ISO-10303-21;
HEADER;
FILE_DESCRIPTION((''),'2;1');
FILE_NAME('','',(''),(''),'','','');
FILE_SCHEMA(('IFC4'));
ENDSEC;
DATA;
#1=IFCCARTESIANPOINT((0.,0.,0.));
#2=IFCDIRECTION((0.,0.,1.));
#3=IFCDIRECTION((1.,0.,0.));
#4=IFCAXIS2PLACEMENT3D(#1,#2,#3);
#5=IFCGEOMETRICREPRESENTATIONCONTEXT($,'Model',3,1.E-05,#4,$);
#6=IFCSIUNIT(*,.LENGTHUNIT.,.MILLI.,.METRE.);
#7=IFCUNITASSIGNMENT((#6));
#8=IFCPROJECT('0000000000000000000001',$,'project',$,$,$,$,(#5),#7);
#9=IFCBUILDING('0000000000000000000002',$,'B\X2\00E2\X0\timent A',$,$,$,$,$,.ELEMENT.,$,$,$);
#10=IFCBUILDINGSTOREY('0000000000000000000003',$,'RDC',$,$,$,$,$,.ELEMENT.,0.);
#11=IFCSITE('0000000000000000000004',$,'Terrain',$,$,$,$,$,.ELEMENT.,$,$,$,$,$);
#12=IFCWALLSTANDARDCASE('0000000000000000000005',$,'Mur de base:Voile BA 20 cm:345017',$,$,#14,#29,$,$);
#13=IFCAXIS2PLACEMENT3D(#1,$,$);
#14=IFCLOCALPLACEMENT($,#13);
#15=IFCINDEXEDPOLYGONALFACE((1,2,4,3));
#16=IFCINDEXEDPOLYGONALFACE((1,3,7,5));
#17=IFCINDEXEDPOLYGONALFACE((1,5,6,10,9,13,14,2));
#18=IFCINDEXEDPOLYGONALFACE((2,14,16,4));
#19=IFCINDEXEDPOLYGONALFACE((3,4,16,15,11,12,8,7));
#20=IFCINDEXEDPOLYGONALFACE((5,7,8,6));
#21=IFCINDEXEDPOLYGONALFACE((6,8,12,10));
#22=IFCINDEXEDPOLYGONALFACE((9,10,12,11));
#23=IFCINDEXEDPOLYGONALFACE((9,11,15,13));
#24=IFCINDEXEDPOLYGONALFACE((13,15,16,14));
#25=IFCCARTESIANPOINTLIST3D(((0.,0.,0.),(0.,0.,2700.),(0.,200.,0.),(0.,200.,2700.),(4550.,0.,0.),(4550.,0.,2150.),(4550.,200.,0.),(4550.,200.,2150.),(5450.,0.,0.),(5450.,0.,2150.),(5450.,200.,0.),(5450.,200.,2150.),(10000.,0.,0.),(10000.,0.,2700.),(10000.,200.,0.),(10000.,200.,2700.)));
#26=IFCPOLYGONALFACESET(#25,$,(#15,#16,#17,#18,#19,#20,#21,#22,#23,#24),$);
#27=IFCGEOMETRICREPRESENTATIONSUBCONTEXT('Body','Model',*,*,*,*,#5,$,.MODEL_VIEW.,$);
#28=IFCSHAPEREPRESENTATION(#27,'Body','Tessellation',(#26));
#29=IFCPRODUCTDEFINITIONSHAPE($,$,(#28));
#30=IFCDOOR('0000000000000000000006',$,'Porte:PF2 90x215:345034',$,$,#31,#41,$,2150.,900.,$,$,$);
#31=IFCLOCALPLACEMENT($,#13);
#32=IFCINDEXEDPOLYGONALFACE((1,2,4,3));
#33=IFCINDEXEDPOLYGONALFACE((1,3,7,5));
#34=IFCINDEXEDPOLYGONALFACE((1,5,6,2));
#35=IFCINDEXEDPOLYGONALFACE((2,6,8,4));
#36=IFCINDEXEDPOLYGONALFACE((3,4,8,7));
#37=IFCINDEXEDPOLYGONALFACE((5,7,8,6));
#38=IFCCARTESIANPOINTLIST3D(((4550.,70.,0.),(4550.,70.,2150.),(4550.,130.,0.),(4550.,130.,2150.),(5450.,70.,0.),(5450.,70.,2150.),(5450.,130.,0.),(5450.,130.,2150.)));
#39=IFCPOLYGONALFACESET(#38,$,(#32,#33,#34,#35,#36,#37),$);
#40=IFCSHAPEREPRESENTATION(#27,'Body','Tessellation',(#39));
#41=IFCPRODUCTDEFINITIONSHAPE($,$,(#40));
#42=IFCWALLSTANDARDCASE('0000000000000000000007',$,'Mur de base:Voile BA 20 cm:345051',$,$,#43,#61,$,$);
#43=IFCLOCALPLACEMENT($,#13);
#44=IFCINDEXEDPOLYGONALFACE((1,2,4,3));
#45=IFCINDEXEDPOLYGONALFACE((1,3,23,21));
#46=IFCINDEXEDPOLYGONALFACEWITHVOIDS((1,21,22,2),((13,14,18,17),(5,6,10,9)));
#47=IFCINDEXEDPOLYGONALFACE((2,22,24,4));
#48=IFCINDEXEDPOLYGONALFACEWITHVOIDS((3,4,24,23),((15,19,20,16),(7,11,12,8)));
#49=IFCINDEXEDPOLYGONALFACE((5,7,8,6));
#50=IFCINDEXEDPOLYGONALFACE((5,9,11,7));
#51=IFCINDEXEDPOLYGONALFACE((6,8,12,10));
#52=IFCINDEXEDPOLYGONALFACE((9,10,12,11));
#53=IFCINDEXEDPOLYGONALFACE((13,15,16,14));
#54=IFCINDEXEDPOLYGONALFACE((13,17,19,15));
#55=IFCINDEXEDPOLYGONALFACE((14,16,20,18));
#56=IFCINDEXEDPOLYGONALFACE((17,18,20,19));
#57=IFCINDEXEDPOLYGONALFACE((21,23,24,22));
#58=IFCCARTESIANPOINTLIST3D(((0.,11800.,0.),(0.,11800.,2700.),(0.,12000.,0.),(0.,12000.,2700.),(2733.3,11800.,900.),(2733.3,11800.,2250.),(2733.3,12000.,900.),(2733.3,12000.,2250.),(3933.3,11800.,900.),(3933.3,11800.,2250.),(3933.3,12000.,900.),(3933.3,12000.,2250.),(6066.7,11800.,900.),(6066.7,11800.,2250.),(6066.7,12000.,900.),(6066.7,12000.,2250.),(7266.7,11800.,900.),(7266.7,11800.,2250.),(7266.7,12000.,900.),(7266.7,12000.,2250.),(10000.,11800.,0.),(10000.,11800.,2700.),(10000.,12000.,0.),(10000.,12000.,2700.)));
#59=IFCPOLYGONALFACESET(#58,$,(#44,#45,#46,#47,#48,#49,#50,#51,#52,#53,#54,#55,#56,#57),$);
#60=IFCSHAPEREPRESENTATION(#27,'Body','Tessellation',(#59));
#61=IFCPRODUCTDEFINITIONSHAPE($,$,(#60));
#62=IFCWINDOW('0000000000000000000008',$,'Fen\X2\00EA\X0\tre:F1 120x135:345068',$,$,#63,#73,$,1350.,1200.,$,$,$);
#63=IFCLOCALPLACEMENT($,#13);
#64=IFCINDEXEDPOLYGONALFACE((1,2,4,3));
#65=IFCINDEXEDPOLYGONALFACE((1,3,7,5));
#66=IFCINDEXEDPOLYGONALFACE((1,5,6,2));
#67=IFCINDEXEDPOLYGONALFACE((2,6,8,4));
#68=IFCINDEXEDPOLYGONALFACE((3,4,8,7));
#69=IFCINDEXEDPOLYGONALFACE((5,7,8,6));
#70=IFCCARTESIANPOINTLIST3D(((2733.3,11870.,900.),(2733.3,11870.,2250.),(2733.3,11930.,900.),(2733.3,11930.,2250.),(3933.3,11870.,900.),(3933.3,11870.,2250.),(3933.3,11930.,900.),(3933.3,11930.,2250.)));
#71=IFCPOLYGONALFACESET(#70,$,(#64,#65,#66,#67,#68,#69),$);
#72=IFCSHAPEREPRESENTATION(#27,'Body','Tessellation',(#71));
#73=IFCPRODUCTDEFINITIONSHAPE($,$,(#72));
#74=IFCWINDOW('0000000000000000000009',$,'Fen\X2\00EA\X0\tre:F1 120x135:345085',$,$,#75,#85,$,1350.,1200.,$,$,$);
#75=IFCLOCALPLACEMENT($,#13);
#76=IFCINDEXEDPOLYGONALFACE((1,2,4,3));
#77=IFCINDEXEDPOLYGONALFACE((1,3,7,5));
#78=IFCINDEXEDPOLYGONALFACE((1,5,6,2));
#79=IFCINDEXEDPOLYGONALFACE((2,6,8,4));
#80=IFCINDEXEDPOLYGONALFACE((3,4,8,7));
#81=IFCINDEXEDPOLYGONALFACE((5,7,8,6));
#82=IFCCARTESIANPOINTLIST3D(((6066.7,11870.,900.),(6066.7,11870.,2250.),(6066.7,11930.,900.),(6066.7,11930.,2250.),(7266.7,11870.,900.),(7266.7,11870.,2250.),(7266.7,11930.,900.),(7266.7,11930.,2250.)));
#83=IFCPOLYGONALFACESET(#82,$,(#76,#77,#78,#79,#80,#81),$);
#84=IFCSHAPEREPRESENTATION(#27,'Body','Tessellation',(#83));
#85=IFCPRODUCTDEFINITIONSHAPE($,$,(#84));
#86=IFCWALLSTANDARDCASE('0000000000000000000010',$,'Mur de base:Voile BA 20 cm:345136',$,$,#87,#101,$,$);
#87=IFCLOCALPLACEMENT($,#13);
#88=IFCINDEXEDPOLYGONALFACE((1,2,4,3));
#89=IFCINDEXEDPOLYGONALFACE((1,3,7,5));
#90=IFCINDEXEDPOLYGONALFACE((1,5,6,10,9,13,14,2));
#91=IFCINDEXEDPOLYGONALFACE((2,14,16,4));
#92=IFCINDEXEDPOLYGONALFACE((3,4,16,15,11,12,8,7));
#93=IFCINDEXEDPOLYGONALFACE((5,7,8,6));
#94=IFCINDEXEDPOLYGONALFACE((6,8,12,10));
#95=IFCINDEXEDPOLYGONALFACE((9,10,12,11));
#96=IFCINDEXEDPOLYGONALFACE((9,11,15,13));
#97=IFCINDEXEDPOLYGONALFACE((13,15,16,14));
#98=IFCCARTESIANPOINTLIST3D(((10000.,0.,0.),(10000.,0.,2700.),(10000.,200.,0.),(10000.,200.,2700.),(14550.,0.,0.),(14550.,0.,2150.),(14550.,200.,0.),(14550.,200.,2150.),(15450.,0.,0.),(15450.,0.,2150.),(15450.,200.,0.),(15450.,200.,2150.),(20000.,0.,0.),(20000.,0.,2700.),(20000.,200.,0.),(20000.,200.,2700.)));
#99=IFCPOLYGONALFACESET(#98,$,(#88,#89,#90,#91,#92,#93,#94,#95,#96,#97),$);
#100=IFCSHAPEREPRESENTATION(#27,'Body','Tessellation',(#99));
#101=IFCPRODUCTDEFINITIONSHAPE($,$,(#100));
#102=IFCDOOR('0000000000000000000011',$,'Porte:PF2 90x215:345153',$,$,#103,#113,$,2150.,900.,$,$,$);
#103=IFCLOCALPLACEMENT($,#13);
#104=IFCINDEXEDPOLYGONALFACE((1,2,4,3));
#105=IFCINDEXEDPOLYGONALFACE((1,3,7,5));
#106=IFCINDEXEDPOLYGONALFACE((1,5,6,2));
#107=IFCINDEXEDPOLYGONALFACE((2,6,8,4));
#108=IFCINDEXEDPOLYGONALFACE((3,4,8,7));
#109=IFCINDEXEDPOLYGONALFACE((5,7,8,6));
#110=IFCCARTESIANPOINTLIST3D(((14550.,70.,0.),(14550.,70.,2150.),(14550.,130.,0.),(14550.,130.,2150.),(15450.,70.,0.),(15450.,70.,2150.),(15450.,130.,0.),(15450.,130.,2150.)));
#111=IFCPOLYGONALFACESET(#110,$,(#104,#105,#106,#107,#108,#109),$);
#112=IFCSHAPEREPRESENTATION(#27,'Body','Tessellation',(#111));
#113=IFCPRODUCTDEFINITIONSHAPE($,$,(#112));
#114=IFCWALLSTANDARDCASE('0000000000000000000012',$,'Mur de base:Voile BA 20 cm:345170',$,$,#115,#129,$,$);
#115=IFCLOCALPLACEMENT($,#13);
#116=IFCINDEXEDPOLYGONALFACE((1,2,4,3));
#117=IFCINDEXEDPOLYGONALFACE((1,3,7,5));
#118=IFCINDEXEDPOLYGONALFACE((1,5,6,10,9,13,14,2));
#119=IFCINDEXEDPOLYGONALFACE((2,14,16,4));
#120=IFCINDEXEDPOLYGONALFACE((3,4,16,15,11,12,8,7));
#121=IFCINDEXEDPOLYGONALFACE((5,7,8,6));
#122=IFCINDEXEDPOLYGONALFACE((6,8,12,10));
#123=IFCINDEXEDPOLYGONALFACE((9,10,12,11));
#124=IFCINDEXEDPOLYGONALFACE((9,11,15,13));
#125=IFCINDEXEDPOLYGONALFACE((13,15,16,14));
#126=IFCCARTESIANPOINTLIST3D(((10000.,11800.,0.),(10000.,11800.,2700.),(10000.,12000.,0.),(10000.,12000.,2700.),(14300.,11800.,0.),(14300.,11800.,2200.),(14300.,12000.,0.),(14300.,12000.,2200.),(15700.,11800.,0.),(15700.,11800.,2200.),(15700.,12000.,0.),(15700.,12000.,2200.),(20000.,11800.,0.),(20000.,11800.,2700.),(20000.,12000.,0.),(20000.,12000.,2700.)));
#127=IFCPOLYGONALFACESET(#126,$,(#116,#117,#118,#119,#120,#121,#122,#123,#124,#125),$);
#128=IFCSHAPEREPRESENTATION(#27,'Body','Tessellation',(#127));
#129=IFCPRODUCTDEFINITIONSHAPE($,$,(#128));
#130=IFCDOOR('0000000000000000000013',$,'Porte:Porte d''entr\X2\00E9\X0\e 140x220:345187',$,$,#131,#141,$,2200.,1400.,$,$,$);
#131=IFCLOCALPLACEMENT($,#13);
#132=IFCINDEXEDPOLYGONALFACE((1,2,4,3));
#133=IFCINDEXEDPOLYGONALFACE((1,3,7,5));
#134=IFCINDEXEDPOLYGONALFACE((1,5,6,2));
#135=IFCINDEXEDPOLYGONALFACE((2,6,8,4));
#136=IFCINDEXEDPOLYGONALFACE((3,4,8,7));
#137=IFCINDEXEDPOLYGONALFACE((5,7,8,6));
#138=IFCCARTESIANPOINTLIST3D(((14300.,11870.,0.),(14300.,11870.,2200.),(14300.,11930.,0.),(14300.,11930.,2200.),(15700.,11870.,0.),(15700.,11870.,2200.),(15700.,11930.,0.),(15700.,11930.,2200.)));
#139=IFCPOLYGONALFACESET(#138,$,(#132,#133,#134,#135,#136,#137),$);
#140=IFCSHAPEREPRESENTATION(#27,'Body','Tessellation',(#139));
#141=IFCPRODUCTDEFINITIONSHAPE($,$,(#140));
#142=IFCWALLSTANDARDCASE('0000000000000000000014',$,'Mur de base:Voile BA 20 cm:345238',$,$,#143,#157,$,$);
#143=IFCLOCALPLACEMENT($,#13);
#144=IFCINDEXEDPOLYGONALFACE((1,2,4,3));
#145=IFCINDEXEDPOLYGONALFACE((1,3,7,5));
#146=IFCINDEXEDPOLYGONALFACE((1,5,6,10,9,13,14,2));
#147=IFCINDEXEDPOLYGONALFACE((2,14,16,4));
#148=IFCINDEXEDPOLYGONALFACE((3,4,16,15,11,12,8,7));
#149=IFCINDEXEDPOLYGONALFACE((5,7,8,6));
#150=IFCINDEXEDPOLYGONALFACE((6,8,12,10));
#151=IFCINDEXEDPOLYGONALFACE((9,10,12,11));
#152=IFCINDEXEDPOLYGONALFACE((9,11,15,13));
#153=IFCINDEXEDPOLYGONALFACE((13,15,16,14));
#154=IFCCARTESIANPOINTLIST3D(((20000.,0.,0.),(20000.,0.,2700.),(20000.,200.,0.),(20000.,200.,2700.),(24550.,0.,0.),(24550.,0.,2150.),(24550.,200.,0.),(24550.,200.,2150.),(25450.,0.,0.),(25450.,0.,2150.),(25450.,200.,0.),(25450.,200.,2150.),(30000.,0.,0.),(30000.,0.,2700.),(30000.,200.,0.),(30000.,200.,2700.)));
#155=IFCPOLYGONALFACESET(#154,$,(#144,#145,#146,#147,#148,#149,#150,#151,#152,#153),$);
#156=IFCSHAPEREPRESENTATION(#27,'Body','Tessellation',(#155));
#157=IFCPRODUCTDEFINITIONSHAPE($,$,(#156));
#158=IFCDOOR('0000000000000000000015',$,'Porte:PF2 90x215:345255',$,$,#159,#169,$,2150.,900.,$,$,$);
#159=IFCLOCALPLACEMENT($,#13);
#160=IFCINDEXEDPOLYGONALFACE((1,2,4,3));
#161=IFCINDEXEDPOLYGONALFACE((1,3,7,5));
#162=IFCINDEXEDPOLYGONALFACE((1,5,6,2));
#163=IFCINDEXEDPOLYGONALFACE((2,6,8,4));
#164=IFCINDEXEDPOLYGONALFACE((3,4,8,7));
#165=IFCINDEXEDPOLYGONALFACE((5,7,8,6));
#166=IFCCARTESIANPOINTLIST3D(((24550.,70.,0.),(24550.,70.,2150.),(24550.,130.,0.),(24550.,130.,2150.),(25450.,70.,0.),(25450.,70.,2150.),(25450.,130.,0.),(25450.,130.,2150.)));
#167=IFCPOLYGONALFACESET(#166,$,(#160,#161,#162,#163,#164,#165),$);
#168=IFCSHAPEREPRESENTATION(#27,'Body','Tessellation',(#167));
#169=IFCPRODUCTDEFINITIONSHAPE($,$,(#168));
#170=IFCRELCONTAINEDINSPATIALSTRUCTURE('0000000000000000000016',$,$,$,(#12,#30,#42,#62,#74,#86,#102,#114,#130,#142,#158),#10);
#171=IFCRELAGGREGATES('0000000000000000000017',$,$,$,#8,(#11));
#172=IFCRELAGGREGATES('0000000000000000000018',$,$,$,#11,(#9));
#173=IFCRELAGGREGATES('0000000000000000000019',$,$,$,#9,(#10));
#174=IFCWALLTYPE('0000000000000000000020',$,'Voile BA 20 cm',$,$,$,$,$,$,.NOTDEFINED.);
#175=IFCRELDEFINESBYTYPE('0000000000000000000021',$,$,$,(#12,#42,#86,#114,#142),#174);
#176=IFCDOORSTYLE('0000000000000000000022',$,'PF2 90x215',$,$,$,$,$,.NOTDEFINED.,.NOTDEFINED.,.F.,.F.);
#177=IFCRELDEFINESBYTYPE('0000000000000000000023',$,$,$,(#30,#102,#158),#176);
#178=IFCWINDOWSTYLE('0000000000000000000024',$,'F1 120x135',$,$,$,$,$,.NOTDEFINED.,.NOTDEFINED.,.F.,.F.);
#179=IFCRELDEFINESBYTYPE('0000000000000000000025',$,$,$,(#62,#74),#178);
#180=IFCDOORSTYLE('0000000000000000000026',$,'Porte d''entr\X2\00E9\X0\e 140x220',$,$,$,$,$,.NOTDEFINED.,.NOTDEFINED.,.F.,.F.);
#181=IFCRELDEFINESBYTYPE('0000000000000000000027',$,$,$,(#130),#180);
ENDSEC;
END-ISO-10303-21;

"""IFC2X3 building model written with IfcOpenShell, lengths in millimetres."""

from ifc_helpers import new_model, si_unit, frame, frame_2d, origin_with_axes, place, context, subcontext, project, spatial, rectangle, extrude, type_object, element, fill, save


model = new_model("IFC2X3")

# Units and contexts
model_context = context("Model", 3, precision=1e-05, world=origin_with_axes())
body_context = subcontext(model_context, "Body", "Model", "MODEL_VIEW")
ifc_project = project(units=[si_unit("LENGTHUNIT", "METRE", prefix="MILLI")], contexts=[model_context])

# Site, building, storey
site = spatial("IfcSite", under=ifc_project, Name="Terrain", CompositionType="ELEMENT")
building = spatial("IfcBuilding", under=site, Name="Bâtiment A", CompositionType="ELEMENT")
storey = spatial("IfcBuildingStorey", under=building, Name="RDC", CompositionType="ELEMENT", Elevation=0.0)

# Wall, opening, door
wall_type_1 = type_object("IfcWallType", Name="Voile BA 20 cm", PredefinedType="NOTDEFINED")
wall_1_placement = place(None, origin_with_axes())
wall_1 = element("IfcWallStandardCase", 1, at=wall_1_placement, inside=storey, type_object=wall_type_1, Name="Mur de base:Voile BA 20 cm:345017", context=body_context, shape_type="SweptSolid", body=[
    extrude(rectangle(XDim=10000.0, YDim=200.0, at=frame_2d((5000.0, 100.0))), origin_with_axes(), (0.0, 0.0, 1.0), 2700.0),
])
opening_1_placement = place(None, origin_with_axes())
opening_1 = element("IfcOpeningElement", 2, at=opening_1_placement, cuts=wall_1, context=body_context, shape_type="SweptSolid", body=[
    extrude(rectangle(XDim=900.0, YDim=320.0, at=frame_2d((5000.0, 100.0))), origin_with_axes(), (0.0, 0.0, 1.0), 2150.0),
])
door_style_1 = type_object("IfcDoorStyle", Name="PF2 90x215", ConstructionType="NOTDEFINED", OperationType="NOTDEFINED", ParameterTakesPrecedence=False, Sizeable=False)
door_1_placement = place(None, origin_with_axes())
door_1 = element("IfcDoor", 3, at=door_1_placement, inside=storey, type_object=door_style_1, Name="Porte:PF2 90x215:345034", OverallHeight=2150.0, OverallWidth=900.0, context=body_context, shape_type="SweptSolid", body=[
    extrude(rectangle(XDim=900.0, YDim=60.0, at=frame_2d((5000.0, 100.0))), origin_with_axes(), (0.0, 0.0, 1.0), 2150.0),
])
fill(opening_1, door_1)

# Wall, openings, windows
wall_2_placement = place(None, origin_with_axes())
wall_2 = element("IfcWallStandardCase", 4, at=wall_2_placement, inside=storey, type_object=wall_type_1, Name="Mur de base:Voile BA 20 cm:345051", context=body_context, shape_type="SweptSolid", body=[
    extrude(rectangle(XDim=10000.0, YDim=200.0, at=frame_2d((5000.0, 11900.0))), origin_with_axes(), (0.0, 0.0, 1.0), 2700.0),
])
opening_2_placement = place(None, origin_with_axes())
opening_2 = element("IfcOpeningElement", 5, at=opening_2_placement, cuts=wall_2, context=body_context, shape_type="SweptSolid", body=[
    extrude(rectangle(XDim=1200.0, YDim=320.0, at=frame_2d((3333.3, 11900.0))), frame((0.0, 0.0, 900.0), z_axis=(0.0, 0.0, 1.0), x_axis=(1.0, 0.0, 0.0)), (0.0, 0.0, 1.0), 1350.0),
])
opening_3_placement = place(None, origin_with_axes())
opening_3 = element("IfcOpeningElement", 6, at=opening_3_placement, cuts=wall_2, context=body_context, shape_type="SweptSolid", body=[
    extrude(rectangle(XDim=1200.0, YDim=320.0, at=frame_2d((6666.7, 11900.0))), frame((0.0, 0.0, 900.0), z_axis=(0.0, 0.0, 1.0), x_axis=(1.0, 0.0, 0.0)), (0.0, 0.0, 1.0), 1350.0),
])
window_style = type_object("IfcWindowStyle", Name="F1 120x135", ConstructionType="NOTDEFINED", OperationType="NOTDEFINED", ParameterTakesPrecedence=False, Sizeable=False)
window_1_placement = place(None, origin_with_axes())
window_1 = element("IfcWindow", 7, at=window_1_placement, inside=storey, type_object=window_style, Name="Fenêtre:F1 120x135:345068", OverallHeight=1350.0, OverallWidth=1200.0, context=body_context, shape_type="SweptSolid", body=[
    extrude(rectangle(XDim=1200.0, YDim=60.0, at=frame_2d((3333.3, 11900.0))), frame((0.0, 0.0, 900.0), z_axis=(0.0, 0.0, 1.0), x_axis=(1.0, 0.0, 0.0)), (0.0, 0.0, 1.0), 1350.0),
])
fill(opening_2, window_1)
window_2_placement = place(None, origin_with_axes())
window_2 = element("IfcWindow", 8, at=window_2_placement, inside=storey, type_object=window_style, Name="Fenêtre:F1 120x135:345085", OverallHeight=1350.0, OverallWidth=1200.0, context=body_context, shape_type="SweptSolid", body=[
    extrude(rectangle(XDim=1200.0, YDim=60.0, at=frame_2d((6666.7, 11900.0))), frame((0.0, 0.0, 900.0), z_axis=(0.0, 0.0, 1.0), x_axis=(1.0, 0.0, 0.0)), (0.0, 0.0, 1.0), 1350.0),
])
fill(opening_3, window_2)

# Walls, openings, doors
wall_3_placement = place(None, origin_with_axes())
wall_3 = element("IfcWallStandardCase", 9, at=wall_3_placement, inside=storey, type_object=wall_type_1, Name="Mur de base:Voile BA 20 cm:345136", context=body_context, shape_type="SweptSolid", body=[
    extrude(rectangle(XDim=10000.0, YDim=200.0, at=frame_2d((15000.0, 100.0))), origin_with_axes(), (0.0, 0.0, 1.0), 2700.0),
])
opening_4_placement = place(None, origin_with_axes())
opening_4 = element("IfcOpeningElement", 10, at=opening_4_placement, cuts=wall_3, context=body_context, shape_type="SweptSolid", body=[
    extrude(rectangle(XDim=900.0, YDim=320.0, at=frame_2d((15000.0, 100.0))), origin_with_axes(), (0.0, 0.0, 1.0), 2150.0),
])
door_2_placement = place(None, origin_with_axes())
door_2 = element("IfcDoor", 11, at=door_2_placement, inside=storey, type_object=door_style_1, Name="Porte:PF2 90x215:345153", OverallHeight=2150.0, OverallWidth=900.0, context=body_context, shape_type="SweptSolid", body=[
    extrude(rectangle(XDim=900.0, YDim=60.0, at=frame_2d((15000.0, 100.0))), origin_with_axes(), (0.0, 0.0, 1.0), 2150.0),
])
fill(opening_4, door_2)
wall_4_placement = place(None, origin_with_axes())
wall_4 = element("IfcWallStandardCase", 12, at=wall_4_placement, inside=storey, type_object=wall_type_1, Name="Mur de base:Voile BA 20 cm:345170", context=body_context, shape_type="SweptSolid", body=[
    extrude(rectangle(XDim=10000.0, YDim=200.0, at=frame_2d((15000.0, 11900.0))), origin_with_axes(), (0.0, 0.0, 1.0), 2700.0),
])
opening_5_placement = place(None, origin_with_axes())
opening_5 = element("IfcOpeningElement", 13, at=opening_5_placement, cuts=wall_4, context=body_context, shape_type="SweptSolid", body=[
    extrude(rectangle(XDim=1400.0, YDim=320.0, at=frame_2d((15000.0, 11900.0))), origin_with_axes(), (0.0, 0.0, 1.0), 2200.0),
])
door_style_2 = type_object("IfcDoorStyle", Name="Porte d'entrée 140x220", ConstructionType="NOTDEFINED", OperationType="NOTDEFINED", ParameterTakesPrecedence=False, Sizeable=False)
door_3_placement = place(None, origin_with_axes())
door_3 = element("IfcDoor", 14, at=door_3_placement, inside=storey, type_object=door_style_2, Name="Porte:Porte d'entrée 140x220:345187", OverallHeight=2200.0, OverallWidth=1400.0, context=body_context, shape_type="SweptSolid", body=[
    extrude(rectangle(XDim=1400.0, YDim=60.0, at=frame_2d((15000.0, 11900.0))), origin_with_axes(), (0.0, 0.0, 1.0), 2200.0),
])
fill(opening_5, door_3)
wall_5_placement = place(None, origin_with_axes())
wall_5 = element("IfcWallStandardCase", 15, at=wall_5_placement, inside=storey, type_object=wall_type_1, Name="Mur de base:Voile BA 20 cm:345238", context=body_context, shape_type="SweptSolid", body=[
    extrude(rectangle(XDim=10000.0, YDim=200.0, at=frame_2d((25000.0, 100.0))), origin_with_axes(), (0.0, 0.0, 1.0), 2700.0),
])
opening_6_placement = place(None, origin_with_axes())
opening_6 = element("IfcOpeningElement", 16, at=opening_6_placement, cuts=wall_5, context=body_context, shape_type="SweptSolid", body=[
    extrude(rectangle(XDim=900.0, YDim=320.0, at=frame_2d((25000.0, 100.0))), origin_with_axes(), (0.0, 0.0, 1.0), 2150.0),
])
door_4_placement = place(None, origin_with_axes())
door_4 = element("IfcDoor", 17, at=door_4_placement, inside=storey, type_object=door_style_1, Name="Porte:PF2 90x215:345255", OverallHeight=2150.0, OverallWidth=900.0, context=body_context, shape_type="SweptSolid", body=[
    extrude(rectangle(XDim=900.0, YDim=60.0, at=frame_2d((25000.0, 100.0))), origin_with_axes(), (0.0, 0.0, 1.0), 2150.0),
])
fill(opening_6, door_4)

save(model, "model.ifc")
